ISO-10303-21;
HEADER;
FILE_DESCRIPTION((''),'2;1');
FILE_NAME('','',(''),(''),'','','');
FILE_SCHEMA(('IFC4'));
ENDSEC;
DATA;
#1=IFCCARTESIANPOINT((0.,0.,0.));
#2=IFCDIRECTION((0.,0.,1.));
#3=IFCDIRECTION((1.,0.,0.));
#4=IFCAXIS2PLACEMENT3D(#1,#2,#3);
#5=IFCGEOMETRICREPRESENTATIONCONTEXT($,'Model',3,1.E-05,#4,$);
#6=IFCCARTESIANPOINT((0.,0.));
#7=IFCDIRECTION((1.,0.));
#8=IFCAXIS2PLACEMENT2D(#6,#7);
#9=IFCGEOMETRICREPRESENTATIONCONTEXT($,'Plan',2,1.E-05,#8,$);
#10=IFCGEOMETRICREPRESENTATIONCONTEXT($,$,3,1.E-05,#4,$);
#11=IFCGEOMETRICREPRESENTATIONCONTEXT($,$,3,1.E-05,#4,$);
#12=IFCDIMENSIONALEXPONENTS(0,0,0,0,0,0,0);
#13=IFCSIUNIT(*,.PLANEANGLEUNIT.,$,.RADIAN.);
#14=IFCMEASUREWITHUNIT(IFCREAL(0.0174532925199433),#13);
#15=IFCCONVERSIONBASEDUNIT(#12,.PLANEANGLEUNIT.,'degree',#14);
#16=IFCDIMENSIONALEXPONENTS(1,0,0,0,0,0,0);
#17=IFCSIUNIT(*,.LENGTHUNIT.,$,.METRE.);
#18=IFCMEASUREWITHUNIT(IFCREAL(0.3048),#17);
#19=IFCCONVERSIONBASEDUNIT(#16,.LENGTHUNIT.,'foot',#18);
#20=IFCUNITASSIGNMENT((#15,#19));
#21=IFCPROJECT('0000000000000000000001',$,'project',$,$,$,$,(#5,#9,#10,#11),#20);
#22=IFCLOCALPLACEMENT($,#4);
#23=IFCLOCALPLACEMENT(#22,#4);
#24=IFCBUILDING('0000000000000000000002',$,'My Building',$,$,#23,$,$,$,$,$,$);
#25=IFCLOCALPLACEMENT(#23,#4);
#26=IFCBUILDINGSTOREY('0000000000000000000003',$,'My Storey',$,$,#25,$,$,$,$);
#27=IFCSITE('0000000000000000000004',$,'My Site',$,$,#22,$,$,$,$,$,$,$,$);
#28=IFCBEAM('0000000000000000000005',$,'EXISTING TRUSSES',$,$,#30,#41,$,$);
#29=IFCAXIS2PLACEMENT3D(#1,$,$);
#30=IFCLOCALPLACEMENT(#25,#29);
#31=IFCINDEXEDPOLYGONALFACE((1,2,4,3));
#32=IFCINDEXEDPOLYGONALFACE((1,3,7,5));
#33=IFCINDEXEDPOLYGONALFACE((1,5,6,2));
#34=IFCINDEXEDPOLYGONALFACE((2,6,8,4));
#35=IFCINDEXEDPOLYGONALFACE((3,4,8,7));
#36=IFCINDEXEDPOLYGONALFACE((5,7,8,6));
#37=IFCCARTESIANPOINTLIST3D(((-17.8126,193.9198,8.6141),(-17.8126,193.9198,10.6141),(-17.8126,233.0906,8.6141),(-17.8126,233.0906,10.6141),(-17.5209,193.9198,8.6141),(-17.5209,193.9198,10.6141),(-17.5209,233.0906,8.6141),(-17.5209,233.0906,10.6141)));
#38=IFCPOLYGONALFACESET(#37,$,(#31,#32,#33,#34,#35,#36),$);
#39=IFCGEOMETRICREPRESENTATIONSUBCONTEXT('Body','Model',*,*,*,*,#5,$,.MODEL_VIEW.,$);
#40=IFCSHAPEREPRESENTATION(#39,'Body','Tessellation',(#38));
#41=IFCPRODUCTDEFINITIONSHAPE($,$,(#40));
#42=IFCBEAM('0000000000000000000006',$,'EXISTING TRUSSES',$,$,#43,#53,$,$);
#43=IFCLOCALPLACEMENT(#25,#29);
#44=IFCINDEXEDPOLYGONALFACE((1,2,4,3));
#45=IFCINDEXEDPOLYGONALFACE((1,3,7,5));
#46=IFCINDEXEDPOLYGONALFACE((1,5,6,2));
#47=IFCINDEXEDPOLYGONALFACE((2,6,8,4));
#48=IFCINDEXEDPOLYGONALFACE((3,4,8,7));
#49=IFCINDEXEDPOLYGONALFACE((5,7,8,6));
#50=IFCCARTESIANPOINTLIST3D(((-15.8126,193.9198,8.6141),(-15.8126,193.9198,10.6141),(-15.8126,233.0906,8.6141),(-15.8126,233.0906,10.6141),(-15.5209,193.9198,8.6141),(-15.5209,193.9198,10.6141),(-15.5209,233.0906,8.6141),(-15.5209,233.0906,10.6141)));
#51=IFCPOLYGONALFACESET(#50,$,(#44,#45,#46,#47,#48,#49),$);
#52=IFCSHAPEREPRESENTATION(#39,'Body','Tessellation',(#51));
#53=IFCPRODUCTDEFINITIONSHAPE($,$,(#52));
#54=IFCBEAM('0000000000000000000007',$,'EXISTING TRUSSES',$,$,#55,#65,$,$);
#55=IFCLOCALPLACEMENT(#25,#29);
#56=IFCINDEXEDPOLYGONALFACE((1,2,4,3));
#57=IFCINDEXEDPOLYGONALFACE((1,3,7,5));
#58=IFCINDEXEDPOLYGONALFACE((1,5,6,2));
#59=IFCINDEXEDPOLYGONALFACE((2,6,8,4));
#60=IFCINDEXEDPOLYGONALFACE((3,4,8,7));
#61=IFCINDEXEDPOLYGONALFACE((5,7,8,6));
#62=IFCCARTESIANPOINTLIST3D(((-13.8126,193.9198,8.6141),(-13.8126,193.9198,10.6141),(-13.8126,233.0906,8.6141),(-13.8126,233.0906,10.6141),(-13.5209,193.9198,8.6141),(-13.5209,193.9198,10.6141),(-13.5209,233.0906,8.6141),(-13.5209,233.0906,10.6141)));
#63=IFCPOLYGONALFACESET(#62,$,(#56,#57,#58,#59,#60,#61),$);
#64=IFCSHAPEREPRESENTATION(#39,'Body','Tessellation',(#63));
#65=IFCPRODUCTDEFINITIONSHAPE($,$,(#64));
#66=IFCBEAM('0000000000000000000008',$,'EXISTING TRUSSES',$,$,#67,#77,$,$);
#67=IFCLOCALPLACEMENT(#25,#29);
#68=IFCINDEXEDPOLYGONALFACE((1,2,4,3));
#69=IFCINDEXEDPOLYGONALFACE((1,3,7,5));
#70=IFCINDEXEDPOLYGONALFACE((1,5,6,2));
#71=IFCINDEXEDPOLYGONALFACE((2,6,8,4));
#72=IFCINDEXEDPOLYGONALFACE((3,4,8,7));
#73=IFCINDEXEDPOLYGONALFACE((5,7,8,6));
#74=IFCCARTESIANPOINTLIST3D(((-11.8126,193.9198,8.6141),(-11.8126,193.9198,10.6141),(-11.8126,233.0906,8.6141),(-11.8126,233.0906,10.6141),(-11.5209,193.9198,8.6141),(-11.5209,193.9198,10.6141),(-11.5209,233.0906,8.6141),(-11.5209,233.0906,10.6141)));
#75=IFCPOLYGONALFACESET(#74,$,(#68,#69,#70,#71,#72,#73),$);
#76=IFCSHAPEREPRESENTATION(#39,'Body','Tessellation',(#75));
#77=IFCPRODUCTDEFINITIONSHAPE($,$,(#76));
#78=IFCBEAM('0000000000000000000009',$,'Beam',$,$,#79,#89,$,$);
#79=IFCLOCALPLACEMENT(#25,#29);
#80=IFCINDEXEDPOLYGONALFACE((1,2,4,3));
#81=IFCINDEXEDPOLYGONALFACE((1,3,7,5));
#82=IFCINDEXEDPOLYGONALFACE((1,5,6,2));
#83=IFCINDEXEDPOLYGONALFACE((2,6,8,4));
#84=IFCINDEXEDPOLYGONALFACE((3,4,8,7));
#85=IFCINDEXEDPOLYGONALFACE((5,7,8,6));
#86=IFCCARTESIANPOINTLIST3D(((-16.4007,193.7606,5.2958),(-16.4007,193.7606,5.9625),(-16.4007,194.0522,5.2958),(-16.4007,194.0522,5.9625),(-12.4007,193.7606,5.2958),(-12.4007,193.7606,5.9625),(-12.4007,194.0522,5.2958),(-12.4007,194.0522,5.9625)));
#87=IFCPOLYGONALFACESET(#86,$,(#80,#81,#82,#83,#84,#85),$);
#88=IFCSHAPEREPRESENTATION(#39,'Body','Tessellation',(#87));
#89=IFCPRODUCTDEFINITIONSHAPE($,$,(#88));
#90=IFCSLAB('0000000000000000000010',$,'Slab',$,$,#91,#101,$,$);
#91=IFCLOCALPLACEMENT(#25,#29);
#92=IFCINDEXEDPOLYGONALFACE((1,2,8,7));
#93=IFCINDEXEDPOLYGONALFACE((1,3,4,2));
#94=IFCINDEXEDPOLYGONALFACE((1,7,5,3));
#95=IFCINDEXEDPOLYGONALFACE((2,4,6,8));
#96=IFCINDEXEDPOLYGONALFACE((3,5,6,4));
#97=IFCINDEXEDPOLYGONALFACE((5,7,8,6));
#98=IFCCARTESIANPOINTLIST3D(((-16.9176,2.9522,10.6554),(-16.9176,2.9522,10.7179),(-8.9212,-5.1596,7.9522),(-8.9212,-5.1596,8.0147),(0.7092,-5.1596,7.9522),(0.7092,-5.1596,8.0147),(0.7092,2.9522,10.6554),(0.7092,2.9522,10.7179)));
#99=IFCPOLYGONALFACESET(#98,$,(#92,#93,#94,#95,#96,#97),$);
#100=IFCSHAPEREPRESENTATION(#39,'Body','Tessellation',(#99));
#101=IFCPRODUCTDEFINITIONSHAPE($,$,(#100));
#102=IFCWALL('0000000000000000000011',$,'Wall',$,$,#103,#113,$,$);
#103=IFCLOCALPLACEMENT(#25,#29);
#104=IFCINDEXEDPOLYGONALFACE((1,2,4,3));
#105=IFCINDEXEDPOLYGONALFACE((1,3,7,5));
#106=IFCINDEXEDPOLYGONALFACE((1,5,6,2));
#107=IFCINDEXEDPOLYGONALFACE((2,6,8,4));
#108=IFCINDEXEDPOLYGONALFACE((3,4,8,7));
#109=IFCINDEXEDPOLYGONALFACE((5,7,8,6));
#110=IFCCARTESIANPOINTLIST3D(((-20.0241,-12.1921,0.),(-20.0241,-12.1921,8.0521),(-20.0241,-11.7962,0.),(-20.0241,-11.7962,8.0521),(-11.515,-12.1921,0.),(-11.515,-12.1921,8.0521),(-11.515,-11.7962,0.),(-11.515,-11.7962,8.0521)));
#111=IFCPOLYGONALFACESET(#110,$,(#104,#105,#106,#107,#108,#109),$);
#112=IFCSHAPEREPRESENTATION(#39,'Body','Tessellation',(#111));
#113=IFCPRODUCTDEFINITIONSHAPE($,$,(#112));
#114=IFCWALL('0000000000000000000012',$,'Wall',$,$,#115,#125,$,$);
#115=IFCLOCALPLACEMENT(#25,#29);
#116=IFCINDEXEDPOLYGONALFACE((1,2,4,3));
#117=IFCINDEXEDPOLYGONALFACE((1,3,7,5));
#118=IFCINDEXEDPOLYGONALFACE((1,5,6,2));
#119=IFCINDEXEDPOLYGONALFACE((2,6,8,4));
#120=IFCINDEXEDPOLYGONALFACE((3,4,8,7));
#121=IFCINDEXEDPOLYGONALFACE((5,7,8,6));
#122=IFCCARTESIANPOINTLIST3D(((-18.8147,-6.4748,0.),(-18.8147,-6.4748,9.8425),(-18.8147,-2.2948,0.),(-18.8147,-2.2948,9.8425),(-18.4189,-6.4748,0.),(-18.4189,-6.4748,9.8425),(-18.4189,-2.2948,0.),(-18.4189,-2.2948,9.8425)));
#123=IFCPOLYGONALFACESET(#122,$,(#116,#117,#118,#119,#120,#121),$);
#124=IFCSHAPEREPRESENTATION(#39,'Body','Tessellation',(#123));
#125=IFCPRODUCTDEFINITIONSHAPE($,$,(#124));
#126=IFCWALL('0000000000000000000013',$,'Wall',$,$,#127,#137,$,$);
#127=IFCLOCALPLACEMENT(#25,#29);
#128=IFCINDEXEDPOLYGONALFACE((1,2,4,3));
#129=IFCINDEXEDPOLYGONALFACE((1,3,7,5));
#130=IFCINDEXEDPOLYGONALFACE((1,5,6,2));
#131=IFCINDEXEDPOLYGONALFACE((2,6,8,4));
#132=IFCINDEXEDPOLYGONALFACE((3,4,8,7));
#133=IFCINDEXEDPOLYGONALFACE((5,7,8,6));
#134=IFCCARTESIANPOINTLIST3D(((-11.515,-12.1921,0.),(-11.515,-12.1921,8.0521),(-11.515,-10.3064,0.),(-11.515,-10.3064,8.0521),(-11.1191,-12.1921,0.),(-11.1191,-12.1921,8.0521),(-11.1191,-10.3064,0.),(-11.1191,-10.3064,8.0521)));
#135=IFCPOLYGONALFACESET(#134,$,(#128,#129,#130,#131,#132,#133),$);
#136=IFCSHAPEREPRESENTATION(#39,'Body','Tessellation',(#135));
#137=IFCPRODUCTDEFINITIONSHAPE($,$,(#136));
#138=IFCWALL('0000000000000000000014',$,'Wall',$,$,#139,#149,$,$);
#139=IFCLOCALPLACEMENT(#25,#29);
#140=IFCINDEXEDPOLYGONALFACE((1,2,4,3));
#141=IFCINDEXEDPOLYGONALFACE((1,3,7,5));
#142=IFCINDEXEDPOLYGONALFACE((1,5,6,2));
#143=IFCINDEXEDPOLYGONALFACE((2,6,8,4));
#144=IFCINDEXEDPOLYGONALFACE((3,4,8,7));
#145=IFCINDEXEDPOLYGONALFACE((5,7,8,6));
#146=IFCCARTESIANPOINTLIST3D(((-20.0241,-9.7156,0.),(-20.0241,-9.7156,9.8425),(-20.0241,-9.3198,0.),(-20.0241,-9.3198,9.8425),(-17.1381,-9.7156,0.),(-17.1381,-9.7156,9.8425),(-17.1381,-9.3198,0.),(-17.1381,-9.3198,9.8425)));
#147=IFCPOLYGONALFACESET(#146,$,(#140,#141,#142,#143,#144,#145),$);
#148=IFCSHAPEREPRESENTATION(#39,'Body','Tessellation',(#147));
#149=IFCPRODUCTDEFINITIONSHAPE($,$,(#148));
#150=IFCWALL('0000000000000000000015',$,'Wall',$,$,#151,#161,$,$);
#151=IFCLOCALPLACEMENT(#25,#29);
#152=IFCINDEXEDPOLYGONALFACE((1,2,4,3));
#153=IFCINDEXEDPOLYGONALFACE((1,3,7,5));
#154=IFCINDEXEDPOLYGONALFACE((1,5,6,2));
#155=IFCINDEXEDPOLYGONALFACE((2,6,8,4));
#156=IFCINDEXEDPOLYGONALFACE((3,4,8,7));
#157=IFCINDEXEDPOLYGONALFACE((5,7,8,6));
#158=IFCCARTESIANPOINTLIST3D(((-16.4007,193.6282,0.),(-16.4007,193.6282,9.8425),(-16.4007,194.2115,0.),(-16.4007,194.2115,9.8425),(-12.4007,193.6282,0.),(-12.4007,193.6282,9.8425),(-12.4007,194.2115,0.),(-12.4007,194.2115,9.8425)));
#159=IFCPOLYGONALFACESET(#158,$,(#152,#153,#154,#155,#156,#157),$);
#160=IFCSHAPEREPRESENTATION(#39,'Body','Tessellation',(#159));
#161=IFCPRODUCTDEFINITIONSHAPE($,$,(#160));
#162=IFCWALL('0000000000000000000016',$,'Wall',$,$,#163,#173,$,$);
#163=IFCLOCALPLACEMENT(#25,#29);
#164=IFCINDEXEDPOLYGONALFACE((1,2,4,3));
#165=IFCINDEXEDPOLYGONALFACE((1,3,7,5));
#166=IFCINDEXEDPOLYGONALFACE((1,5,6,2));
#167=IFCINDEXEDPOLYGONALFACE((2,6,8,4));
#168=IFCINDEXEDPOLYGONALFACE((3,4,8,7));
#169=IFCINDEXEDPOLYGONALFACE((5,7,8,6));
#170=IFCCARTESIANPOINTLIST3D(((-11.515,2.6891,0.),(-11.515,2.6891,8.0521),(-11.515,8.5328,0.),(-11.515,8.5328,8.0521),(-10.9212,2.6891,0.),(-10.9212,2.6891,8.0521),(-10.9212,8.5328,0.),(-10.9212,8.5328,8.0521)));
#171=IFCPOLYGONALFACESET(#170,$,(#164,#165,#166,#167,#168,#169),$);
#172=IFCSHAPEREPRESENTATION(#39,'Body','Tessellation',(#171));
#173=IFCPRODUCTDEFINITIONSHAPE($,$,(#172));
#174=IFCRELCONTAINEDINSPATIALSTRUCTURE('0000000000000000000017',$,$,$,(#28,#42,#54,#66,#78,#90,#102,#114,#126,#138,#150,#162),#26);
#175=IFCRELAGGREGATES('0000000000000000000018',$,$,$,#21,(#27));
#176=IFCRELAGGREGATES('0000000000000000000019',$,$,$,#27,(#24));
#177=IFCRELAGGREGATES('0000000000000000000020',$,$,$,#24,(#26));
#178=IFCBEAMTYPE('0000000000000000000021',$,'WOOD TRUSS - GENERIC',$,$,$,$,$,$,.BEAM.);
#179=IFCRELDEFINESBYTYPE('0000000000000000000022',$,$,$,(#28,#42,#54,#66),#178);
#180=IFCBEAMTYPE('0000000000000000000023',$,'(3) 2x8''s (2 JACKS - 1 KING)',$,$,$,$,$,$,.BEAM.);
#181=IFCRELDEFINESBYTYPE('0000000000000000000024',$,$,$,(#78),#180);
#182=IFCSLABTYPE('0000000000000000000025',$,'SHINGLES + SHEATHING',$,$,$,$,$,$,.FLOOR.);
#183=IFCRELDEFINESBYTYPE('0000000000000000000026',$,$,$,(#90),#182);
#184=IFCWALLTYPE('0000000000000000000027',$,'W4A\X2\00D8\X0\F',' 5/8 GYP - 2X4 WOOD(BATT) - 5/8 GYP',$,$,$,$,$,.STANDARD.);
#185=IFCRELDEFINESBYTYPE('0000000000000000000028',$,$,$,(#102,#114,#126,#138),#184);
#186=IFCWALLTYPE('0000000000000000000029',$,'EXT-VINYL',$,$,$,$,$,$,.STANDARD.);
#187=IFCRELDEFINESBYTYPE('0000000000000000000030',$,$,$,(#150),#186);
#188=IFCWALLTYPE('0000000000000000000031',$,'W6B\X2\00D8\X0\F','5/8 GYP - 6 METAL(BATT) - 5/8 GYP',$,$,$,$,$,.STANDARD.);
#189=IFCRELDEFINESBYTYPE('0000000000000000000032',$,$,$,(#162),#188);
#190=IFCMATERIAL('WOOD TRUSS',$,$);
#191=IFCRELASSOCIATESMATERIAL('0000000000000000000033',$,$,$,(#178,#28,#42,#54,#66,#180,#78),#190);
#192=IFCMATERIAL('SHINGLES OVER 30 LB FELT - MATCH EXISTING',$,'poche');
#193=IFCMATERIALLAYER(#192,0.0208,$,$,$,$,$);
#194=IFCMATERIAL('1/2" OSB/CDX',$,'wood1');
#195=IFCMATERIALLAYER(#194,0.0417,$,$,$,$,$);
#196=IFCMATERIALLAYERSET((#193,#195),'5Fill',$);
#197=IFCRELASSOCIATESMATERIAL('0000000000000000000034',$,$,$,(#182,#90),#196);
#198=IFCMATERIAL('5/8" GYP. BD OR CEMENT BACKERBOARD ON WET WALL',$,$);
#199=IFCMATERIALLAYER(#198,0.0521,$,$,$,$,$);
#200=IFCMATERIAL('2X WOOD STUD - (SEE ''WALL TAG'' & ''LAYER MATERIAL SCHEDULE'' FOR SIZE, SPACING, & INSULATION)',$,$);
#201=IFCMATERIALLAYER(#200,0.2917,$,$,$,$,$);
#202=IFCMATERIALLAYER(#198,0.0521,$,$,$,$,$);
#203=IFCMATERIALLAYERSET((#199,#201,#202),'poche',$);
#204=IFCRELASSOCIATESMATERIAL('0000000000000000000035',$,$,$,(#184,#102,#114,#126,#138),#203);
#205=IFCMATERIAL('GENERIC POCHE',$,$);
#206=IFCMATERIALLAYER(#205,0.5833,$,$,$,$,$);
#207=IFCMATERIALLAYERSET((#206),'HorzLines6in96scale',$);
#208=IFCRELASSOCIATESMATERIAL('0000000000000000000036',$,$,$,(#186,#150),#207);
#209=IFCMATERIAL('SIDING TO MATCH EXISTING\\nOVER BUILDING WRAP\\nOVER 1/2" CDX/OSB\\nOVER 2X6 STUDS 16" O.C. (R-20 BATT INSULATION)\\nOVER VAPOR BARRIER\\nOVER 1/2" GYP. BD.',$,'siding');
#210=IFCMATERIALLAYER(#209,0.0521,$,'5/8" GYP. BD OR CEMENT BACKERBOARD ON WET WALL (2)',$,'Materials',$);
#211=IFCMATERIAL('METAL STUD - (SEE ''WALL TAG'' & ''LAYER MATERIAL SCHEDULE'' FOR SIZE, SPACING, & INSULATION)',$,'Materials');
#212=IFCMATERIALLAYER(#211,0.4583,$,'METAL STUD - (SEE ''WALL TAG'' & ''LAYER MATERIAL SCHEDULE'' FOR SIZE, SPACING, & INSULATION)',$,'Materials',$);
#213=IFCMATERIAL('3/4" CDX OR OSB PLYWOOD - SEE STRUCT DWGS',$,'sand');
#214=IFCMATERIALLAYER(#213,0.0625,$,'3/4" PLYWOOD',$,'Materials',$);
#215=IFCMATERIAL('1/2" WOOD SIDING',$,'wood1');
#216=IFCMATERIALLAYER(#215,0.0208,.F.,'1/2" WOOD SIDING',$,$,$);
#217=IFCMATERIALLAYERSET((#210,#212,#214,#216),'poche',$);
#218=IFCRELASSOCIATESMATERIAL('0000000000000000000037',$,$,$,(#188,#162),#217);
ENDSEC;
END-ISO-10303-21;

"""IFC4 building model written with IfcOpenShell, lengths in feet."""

from ifc_helpers import new_model, entity, si_unit, converted_unit, frame, origin_with_axes, origin_2d_with_axis, place, context, subcontext, project, spatial, line, indexed_curve, rectangle, outline, extrude, material, layer, layer_set, layer_usage, material_profile, profile_set, profile_usage, type_object, element, save


model = new_model("IFC4")

# Units and contexts
model_context = context("Model", 3, precision=1e-05, world=origin_with_axes())
plan_context = context("Plan", 2, precision=1e-05, world=origin_2d_with_axis())
context_of_model_1 = context(None, 3, precision=1e-05, world=origin_with_axes())
context_of_model_2 = context(None, 3, precision=1e-05, world=origin_with_axes())
body_context = subcontext(model_context, "Body", "Model", "MODEL_VIEW")
ifc_project = project(units=[converted_unit("PLANEANGLEUNIT", "degree", entity("IfcReal", 0.0174532925199433), si_unit("PLANEANGLEUNIT", "RADIAN"), dimensions=[0, 0, 0, 0, 0, 0, 0]), converted_unit("LENGTHUNIT", "foot", entity("IfcReal", 0.3048), si_unit("LENGTHUNIT", "METRE"), dimensions=[1, 0, 0, 0, 0, 0, 0])], contexts=[model_context, plan_context, context_of_model_1, context_of_model_2])

# Site, building, storey
site_placement = place(None, origin_with_axes())
site = spatial("IfcSite", under=ifc_project, at=site_placement, Name="My Site")
building_placement = place(site_placement, origin_with_axes())
building = spatial("IfcBuilding", under=site, at=building_placement, Name="My Building")
storey_placement = place(building_placement, origin_with_axes())
storey = spatial("IfcBuildingStorey", under=building, at=storey_placement, Name="My Storey")

# Beams
ifc_material_1 = material(Name="WOOD TRUSS")
ifc_material_profile_1 = material_profile(ifc_material_1, rectangle(XDim=0.2917, YDim=2.0))
ifc_profile_set_1 = profile_set([ifc_material_profile_1])
ifc_profile_usage_1 = profile_usage(ifc_profile_set_1, cardinal=5)
beam_type_1 = type_object("IfcBeamType", Name="WOOD TRUSS - GENERIC", PredefinedType="BEAM", material=ifc_profile_set_1)
beam_1_placement = place(storey_placement, frame((-17.6667, 193.9198, 9.6141), z_axis=(0.0, 1.0, 0.0), x_axis=(-1.0, 0.0, 0.0)))
element("IfcBeam", 1, at=beam_1_placement, inside=storey, type_object=beam_type_1, material=ifc_profile_usage_1, Name="EXISTING TRUSSES", context=body_context, shape_type="SweptSolid", body=[
    extrude(rectangle(XDim=0.2917, YDim=2.0), origin_with_axes(), (0.0, 0.0, 1.0), 39.1707),
])
ifc_profile_usage_2 = profile_usage(ifc_profile_set_1, cardinal=5)
beam_2_placement = place(storey_placement, frame((-15.6667, 193.9198, 9.6141), z_axis=(0.0, 1.0, 0.0), x_axis=(-1.0, 0.0, 0.0)))
element("IfcBeam", 2, at=beam_2_placement, inside=storey, type_object=beam_type_1, material=ifc_profile_usage_2, Name="EXISTING TRUSSES", context=body_context, shape_type="SweptSolid", body=[
    extrude(rectangle(XDim=0.2917, YDim=2.0), origin_with_axes(), (0.0, 0.0, 1.0), 39.1707),
])
ifc_profile_usage_3 = profile_usage(ifc_profile_set_1, cardinal=5)
beam_3_placement = place(storey_placement, frame((-13.6667, 193.9198, 9.6141), z_axis=(0.0, 1.0, 0.0), x_axis=(-1.0, 0.0, 0.0)))
element("IfcBeam", 3, at=beam_3_placement, inside=storey, type_object=beam_type_1, material=ifc_profile_usage_3, Name="EXISTING TRUSSES", context=body_context, shape_type="SweptSolid", body=[
    extrude(rectangle(XDim=0.2917, YDim=2.0), origin_with_axes(), (0.0, 0.0, 1.0), 39.1707),
])
ifc_profile_usage_4 = profile_usage(ifc_profile_set_1, cardinal=5)
beam_4_placement = place(storey_placement, frame((-11.6667, 193.9198, 9.6141), z_axis=(0.0, 1.0, 0.0), x_axis=(-1.0, 0.0, 0.0)))
element("IfcBeam", 4, at=beam_4_placement, inside=storey, type_object=beam_type_1, material=ifc_profile_usage_4, Name="EXISTING TRUSSES", context=body_context, shape_type="SweptSolid", body=[
    extrude(rectangle(XDim=0.2917, YDim=2.0), origin_with_axes(), (0.0, 0.0, 1.0), 39.1707),
])
ifc_material_profile_2 = material_profile(ifc_material_1, rectangle(XDim=0.2917, YDim=0.6667))
ifc_profile_set_2 = profile_set([ifc_material_profile_2])
ifc_profile_usage_5 = profile_usage(ifc_profile_set_2, cardinal=5)
beam_type_2 = type_object("IfcBeamType", Name="(3) 2x8's (2 JACKS - 1 KING)", PredefinedType="BEAM", material=ifc_profile_set_2)
beam_5_placement = place(storey_placement, frame((-16.4007, 193.9064, 5.6292), z_axis=(1.0, 0.0, 0.0), x_axis=(0.0, 1.0, 0.0)))
element("IfcBeam", 5, at=beam_5_placement, inside=storey, type_object=beam_type_2, material=ifc_profile_usage_5, Name="Beam", context=body_context, shape_type="SweptSolid", body=[
    extrude(rectangle(XDim=0.2917, YDim=0.6667), origin_with_axes(), (0.0, 0.0, 1.0), 4.0),
])

# Slab
ifc_material_2 = material(Name="SHINGLES OVER 30 LB FELT - MATCH EXISTING", Category="poche")
ifc_layer_1 = layer(ifc_material_2, 0.0208)
ifc_material_3 = material(Name="1/2\" OSB/CDX", Category="wood1")
ifc_layer_2 = layer(ifc_material_3, 0.0417)
ifc_layer_set_1 = layer_set([ifc_layer_1, ifc_layer_2], Name="5Fill")
ifc_layer_usage_1 = layer_usage(ifc_layer_set_1, "AXIS3", "POSITIVE", 0.0)
slab_type_1 = type_object("IfcSlabType", Name="SHINGLES + SHEATHING", PredefinedType="FLOOR", material=ifc_layer_set_1)
slab_1_placement = place(storey_placement, frame((-16.9176, -5.1596, 7.9522), z_axis=(0.0, -0.316146, 0.948711), x_axis=(1.0, 0.000001, 0.0)))
element("IfcSlab", 6, at=slab_1_placement, inside=storey, type_object=slab_type_1, material=ifc_layer_usage_1, Name="Slab", context=body_context, shape_type="SweptSolid", body=[
    extrude(outline(indexed_curve([(7.9964, 0.0), (17.6268, 0.0), (17.6268, 8.5503), (0.0, 8.5503)], segments=[line(3, 2), line(2, 1), line(1, 4), line(4, 3)], self_intersect=False)), None, (0.0, 0.316146, 0.948711), 0.0625),
])

# Walls
ifc_material_4 = material(Name="5/8\" GYP. BD OR CEMENT BACKERBOARD ON WET WALL")
ifc_layer_3 = layer(ifc_material_4, 0.0521)
ifc_material_5 = material(Name="2X WOOD STUD - (SEE 'WALL TAG' & 'LAYER MATERIAL SCHEDULE' FOR SIZE, SPACING, & INSULATION)")
ifc_layer_4 = layer(ifc_material_5, 0.2917)
ifc_layer_5 = layer(ifc_material_4, 0.0521)
ifc_layer_set_2 = layer_set([ifc_layer_3, ifc_layer_4, ifc_layer_5], Name="poche")
ifc_layer_usage_2 = layer_usage(ifc_layer_set_2, "AXIS2", "POSITIVE", 0.0)
wall_type_1 = type_object("IfcWallType", Name="W4AØF", Description=" 5/8 GYP - 2X4 WOOD(BATT) - 5/8 GYP", PredefinedType="STANDARD", material=ifc_layer_set_2)
wall_1_placement = place(storey_placement, frame((-11.515, -11.7962, 0.0), z_axis=(0.0, 0.0, 1.0), x_axis=(-1.0, 0.0, 0.0)))
element("IfcWall", 7, at=wall_1_placement, inside=storey, type_object=wall_type_1, material=ifc_layer_usage_2, Name="Wall", context=body_context, shape_type="SweptSolid", body=[
    extrude(outline(indexed_curve([(0.0, 0.0), (0.0, 0.3958), (8.5091, 0.3958), (8.5091, 0.0), (0.0, 0.0)], self_intersect=False)), origin_with_axes(), (0.0, 0.0, 1.0), 8.0521),
])
ifc_layer_usage_3 = layer_usage(ifc_layer_set_2, "AXIS2", "POSITIVE", 0.0)
wall_2_placement = place(storey_placement, frame((-18.4189, -6.4748, 0.0), z_axis=(0.0, 0.0, 1.0), x_axis=(0.0, 1.0, 0.0)))
element("IfcWall", 8, at=wall_2_placement, inside=storey, type_object=wall_type_1, material=ifc_layer_usage_3, Name="Wall", context=body_context, shape_type="SweptSolid", body=[
    extrude(outline(indexed_curve([(0.0, 0.0), (0.0, 0.3958), (4.18, 0.3958), (4.18, 0.0), (0.0, 0.0)], self_intersect=False)), origin_with_axes(), (0.0, 0.0, 1.0), 9.8425),
])
ifc_layer_usage_4 = layer_usage(ifc_layer_set_2, "AXIS2", "POSITIVE", 0.0)
wall_3_placement = place(storey_placement, frame((-11.515, -10.3064, 0.0), z_axis=(0.0, 0.0, 1.0), x_axis=(0.0, -1.0, 0.0)))
element("IfcWall", 9, at=wall_3_placement, inside=storey, type_object=wall_type_1, material=ifc_layer_usage_4, Name="Wall", context=body_context, shape_type="SweptSolid", body=[
    extrude(outline(indexed_curve([(0.0, 0.0), (0.0, 0.3958), (1.8856, 0.3958), (1.8856, 0.0), (0.0, 0.0)], self_intersect=False)), origin_with_axes(), (0.0, 0.0, 1.0), 8.0521),
])
ifc_layer_usage_5 = layer_usage(ifc_layer_set_2, "AXIS2", "POSITIVE", 0.0)
wall_4_placement = place(storey_placement, frame((-17.1381, -9.3198, 0.0), z_axis=(0.0, 0.0, 1.0), x_axis=(-1.0, 0.0, 0.0)))
element("IfcWall", 10, at=wall_4_placement, inside=storey, type_object=wall_type_1, material=ifc_layer_usage_5, Name="Wall", context=body_context, shape_type="SweptSolid", body=[
    extrude(outline(indexed_curve([(0.0, 0.0), (0.0, 0.3958), (2.886, 0.3958), (2.886, 0.0), (0.0, 0.0)], self_intersect=False)), origin_with_axes(), (0.0, 0.0, 1.0), 9.8425),
])
ifc_material_6 = material(Name="GENERIC POCHE")
ifc_layer_6 = layer(ifc_material_6, 0.5833)
ifc_layer_set_3 = layer_set([ifc_layer_6], Name="HorzLines6in96scale")
ifc_layer_usage_6 = layer_usage(ifc_layer_set_3, "AXIS2", "POSITIVE", 0.0)
wall_type_2 = type_object("IfcWallType", Name="EXT-VINYL", PredefinedType="STANDARD", material=ifc_layer_set_3)
wall_5_placement = place(storey_placement, frame((-12.4007, 194.2115, 0.0), z_axis=(0.0, 0.0, 1.0), x_axis=(-1.0, 0.0, 0.0)))
element("IfcWall", 11, at=wall_5_placement, inside=storey, type_object=wall_type_2, material=ifc_layer_usage_6, Name="Wall", context=body_context, shape_type="SweptSolid", body=[
    extrude(outline(indexed_curve([(0.0, 0.0), (0.0, 0.5833), (4.0, 0.5833), (4.0, 0.0), (0.0, 0.0)], self_intersect=False)), origin_with_axes(), (0.0, 0.0, 1.0), 9.8425),
])
ifc_material_7 = material(Name="SIDING TO MATCH EXISTING\\nOVER BUILDING WRAP\\nOVER 1/2\" CDX/OSB\\nOVER 2X6 STUDS 16\" O.C. (R-20 BATT INSULATION)\\nOVER VAPOR BARRIER\\nOVER 1/2\" GYP. BD.", Category="siding")
ifc_layer_7 = layer(ifc_material_7, 0.0521, Name="5/8\" GYP. BD OR CEMENT BACKERBOARD ON WET WALL (2)", Category="Materials")
ifc_material_8 = material(Name="METAL STUD - (SEE 'WALL TAG' & 'LAYER MATERIAL SCHEDULE' FOR SIZE, SPACING, & INSULATION)", Category="Materials")
ifc_layer_8 = layer(ifc_material_8, 0.4583, Name="METAL STUD - (SEE 'WALL TAG' & 'LAYER MATERIAL SCHEDULE' FOR SIZE, SPACING, & INSULATION)", Category="Materials")
ifc_material_9 = material(Name="3/4\" CDX OR OSB PLYWOOD - SEE STRUCT DWGS", Category="sand")
ifc_layer_9 = layer(ifc_material_9, 0.0625, Name="3/4\" PLYWOOD", Category="Materials")
ifc_material_10 = material(Name="1/2\" WOOD SIDING", Category="wood1")
ifc_layer_10 = layer(ifc_material_10, 0.0208, ventilated=False, Name="1/2\" WOOD SIDING")
ifc_layer_set_4 = layer_set([ifc_layer_7, ifc_layer_8, ifc_layer_9, ifc_layer_10], Name="poche")
ifc_layer_usage_7 = layer_usage(ifc_layer_set_4, "AXIS2", "POSITIVE", 0.0)
wall_type_3 = type_object("IfcWallType", Name="W6BØF", Description="5/8 GYP - 6 METAL(BATT) - 5/8 GYP", PredefinedType="STANDARD", material=ifc_layer_set_4)
wall_6_placement = place(storey_placement, frame((-11.515, 8.5328, 0.0), z_axis=(0.0, 0.0, 1.0), x_axis=(0.0, -1.0, 0.0)))
element("IfcWall", 12, at=wall_6_placement, inside=storey, type_object=wall_type_3, material=ifc_layer_usage_7, Name="Wall", context=body_context, shape_type="SweptSolid", body=[
    extrude(outline(indexed_curve([(0.0, 0.0), (0.0, 0.5937), (5.8437, 0.5937), (5.8437, 0.0), (0.0, 0.0)], self_intersect=False)), origin_with_axes(), (0.0, 0.0, 1.0), 8.0521),
])

save(model, "model.ifc")
